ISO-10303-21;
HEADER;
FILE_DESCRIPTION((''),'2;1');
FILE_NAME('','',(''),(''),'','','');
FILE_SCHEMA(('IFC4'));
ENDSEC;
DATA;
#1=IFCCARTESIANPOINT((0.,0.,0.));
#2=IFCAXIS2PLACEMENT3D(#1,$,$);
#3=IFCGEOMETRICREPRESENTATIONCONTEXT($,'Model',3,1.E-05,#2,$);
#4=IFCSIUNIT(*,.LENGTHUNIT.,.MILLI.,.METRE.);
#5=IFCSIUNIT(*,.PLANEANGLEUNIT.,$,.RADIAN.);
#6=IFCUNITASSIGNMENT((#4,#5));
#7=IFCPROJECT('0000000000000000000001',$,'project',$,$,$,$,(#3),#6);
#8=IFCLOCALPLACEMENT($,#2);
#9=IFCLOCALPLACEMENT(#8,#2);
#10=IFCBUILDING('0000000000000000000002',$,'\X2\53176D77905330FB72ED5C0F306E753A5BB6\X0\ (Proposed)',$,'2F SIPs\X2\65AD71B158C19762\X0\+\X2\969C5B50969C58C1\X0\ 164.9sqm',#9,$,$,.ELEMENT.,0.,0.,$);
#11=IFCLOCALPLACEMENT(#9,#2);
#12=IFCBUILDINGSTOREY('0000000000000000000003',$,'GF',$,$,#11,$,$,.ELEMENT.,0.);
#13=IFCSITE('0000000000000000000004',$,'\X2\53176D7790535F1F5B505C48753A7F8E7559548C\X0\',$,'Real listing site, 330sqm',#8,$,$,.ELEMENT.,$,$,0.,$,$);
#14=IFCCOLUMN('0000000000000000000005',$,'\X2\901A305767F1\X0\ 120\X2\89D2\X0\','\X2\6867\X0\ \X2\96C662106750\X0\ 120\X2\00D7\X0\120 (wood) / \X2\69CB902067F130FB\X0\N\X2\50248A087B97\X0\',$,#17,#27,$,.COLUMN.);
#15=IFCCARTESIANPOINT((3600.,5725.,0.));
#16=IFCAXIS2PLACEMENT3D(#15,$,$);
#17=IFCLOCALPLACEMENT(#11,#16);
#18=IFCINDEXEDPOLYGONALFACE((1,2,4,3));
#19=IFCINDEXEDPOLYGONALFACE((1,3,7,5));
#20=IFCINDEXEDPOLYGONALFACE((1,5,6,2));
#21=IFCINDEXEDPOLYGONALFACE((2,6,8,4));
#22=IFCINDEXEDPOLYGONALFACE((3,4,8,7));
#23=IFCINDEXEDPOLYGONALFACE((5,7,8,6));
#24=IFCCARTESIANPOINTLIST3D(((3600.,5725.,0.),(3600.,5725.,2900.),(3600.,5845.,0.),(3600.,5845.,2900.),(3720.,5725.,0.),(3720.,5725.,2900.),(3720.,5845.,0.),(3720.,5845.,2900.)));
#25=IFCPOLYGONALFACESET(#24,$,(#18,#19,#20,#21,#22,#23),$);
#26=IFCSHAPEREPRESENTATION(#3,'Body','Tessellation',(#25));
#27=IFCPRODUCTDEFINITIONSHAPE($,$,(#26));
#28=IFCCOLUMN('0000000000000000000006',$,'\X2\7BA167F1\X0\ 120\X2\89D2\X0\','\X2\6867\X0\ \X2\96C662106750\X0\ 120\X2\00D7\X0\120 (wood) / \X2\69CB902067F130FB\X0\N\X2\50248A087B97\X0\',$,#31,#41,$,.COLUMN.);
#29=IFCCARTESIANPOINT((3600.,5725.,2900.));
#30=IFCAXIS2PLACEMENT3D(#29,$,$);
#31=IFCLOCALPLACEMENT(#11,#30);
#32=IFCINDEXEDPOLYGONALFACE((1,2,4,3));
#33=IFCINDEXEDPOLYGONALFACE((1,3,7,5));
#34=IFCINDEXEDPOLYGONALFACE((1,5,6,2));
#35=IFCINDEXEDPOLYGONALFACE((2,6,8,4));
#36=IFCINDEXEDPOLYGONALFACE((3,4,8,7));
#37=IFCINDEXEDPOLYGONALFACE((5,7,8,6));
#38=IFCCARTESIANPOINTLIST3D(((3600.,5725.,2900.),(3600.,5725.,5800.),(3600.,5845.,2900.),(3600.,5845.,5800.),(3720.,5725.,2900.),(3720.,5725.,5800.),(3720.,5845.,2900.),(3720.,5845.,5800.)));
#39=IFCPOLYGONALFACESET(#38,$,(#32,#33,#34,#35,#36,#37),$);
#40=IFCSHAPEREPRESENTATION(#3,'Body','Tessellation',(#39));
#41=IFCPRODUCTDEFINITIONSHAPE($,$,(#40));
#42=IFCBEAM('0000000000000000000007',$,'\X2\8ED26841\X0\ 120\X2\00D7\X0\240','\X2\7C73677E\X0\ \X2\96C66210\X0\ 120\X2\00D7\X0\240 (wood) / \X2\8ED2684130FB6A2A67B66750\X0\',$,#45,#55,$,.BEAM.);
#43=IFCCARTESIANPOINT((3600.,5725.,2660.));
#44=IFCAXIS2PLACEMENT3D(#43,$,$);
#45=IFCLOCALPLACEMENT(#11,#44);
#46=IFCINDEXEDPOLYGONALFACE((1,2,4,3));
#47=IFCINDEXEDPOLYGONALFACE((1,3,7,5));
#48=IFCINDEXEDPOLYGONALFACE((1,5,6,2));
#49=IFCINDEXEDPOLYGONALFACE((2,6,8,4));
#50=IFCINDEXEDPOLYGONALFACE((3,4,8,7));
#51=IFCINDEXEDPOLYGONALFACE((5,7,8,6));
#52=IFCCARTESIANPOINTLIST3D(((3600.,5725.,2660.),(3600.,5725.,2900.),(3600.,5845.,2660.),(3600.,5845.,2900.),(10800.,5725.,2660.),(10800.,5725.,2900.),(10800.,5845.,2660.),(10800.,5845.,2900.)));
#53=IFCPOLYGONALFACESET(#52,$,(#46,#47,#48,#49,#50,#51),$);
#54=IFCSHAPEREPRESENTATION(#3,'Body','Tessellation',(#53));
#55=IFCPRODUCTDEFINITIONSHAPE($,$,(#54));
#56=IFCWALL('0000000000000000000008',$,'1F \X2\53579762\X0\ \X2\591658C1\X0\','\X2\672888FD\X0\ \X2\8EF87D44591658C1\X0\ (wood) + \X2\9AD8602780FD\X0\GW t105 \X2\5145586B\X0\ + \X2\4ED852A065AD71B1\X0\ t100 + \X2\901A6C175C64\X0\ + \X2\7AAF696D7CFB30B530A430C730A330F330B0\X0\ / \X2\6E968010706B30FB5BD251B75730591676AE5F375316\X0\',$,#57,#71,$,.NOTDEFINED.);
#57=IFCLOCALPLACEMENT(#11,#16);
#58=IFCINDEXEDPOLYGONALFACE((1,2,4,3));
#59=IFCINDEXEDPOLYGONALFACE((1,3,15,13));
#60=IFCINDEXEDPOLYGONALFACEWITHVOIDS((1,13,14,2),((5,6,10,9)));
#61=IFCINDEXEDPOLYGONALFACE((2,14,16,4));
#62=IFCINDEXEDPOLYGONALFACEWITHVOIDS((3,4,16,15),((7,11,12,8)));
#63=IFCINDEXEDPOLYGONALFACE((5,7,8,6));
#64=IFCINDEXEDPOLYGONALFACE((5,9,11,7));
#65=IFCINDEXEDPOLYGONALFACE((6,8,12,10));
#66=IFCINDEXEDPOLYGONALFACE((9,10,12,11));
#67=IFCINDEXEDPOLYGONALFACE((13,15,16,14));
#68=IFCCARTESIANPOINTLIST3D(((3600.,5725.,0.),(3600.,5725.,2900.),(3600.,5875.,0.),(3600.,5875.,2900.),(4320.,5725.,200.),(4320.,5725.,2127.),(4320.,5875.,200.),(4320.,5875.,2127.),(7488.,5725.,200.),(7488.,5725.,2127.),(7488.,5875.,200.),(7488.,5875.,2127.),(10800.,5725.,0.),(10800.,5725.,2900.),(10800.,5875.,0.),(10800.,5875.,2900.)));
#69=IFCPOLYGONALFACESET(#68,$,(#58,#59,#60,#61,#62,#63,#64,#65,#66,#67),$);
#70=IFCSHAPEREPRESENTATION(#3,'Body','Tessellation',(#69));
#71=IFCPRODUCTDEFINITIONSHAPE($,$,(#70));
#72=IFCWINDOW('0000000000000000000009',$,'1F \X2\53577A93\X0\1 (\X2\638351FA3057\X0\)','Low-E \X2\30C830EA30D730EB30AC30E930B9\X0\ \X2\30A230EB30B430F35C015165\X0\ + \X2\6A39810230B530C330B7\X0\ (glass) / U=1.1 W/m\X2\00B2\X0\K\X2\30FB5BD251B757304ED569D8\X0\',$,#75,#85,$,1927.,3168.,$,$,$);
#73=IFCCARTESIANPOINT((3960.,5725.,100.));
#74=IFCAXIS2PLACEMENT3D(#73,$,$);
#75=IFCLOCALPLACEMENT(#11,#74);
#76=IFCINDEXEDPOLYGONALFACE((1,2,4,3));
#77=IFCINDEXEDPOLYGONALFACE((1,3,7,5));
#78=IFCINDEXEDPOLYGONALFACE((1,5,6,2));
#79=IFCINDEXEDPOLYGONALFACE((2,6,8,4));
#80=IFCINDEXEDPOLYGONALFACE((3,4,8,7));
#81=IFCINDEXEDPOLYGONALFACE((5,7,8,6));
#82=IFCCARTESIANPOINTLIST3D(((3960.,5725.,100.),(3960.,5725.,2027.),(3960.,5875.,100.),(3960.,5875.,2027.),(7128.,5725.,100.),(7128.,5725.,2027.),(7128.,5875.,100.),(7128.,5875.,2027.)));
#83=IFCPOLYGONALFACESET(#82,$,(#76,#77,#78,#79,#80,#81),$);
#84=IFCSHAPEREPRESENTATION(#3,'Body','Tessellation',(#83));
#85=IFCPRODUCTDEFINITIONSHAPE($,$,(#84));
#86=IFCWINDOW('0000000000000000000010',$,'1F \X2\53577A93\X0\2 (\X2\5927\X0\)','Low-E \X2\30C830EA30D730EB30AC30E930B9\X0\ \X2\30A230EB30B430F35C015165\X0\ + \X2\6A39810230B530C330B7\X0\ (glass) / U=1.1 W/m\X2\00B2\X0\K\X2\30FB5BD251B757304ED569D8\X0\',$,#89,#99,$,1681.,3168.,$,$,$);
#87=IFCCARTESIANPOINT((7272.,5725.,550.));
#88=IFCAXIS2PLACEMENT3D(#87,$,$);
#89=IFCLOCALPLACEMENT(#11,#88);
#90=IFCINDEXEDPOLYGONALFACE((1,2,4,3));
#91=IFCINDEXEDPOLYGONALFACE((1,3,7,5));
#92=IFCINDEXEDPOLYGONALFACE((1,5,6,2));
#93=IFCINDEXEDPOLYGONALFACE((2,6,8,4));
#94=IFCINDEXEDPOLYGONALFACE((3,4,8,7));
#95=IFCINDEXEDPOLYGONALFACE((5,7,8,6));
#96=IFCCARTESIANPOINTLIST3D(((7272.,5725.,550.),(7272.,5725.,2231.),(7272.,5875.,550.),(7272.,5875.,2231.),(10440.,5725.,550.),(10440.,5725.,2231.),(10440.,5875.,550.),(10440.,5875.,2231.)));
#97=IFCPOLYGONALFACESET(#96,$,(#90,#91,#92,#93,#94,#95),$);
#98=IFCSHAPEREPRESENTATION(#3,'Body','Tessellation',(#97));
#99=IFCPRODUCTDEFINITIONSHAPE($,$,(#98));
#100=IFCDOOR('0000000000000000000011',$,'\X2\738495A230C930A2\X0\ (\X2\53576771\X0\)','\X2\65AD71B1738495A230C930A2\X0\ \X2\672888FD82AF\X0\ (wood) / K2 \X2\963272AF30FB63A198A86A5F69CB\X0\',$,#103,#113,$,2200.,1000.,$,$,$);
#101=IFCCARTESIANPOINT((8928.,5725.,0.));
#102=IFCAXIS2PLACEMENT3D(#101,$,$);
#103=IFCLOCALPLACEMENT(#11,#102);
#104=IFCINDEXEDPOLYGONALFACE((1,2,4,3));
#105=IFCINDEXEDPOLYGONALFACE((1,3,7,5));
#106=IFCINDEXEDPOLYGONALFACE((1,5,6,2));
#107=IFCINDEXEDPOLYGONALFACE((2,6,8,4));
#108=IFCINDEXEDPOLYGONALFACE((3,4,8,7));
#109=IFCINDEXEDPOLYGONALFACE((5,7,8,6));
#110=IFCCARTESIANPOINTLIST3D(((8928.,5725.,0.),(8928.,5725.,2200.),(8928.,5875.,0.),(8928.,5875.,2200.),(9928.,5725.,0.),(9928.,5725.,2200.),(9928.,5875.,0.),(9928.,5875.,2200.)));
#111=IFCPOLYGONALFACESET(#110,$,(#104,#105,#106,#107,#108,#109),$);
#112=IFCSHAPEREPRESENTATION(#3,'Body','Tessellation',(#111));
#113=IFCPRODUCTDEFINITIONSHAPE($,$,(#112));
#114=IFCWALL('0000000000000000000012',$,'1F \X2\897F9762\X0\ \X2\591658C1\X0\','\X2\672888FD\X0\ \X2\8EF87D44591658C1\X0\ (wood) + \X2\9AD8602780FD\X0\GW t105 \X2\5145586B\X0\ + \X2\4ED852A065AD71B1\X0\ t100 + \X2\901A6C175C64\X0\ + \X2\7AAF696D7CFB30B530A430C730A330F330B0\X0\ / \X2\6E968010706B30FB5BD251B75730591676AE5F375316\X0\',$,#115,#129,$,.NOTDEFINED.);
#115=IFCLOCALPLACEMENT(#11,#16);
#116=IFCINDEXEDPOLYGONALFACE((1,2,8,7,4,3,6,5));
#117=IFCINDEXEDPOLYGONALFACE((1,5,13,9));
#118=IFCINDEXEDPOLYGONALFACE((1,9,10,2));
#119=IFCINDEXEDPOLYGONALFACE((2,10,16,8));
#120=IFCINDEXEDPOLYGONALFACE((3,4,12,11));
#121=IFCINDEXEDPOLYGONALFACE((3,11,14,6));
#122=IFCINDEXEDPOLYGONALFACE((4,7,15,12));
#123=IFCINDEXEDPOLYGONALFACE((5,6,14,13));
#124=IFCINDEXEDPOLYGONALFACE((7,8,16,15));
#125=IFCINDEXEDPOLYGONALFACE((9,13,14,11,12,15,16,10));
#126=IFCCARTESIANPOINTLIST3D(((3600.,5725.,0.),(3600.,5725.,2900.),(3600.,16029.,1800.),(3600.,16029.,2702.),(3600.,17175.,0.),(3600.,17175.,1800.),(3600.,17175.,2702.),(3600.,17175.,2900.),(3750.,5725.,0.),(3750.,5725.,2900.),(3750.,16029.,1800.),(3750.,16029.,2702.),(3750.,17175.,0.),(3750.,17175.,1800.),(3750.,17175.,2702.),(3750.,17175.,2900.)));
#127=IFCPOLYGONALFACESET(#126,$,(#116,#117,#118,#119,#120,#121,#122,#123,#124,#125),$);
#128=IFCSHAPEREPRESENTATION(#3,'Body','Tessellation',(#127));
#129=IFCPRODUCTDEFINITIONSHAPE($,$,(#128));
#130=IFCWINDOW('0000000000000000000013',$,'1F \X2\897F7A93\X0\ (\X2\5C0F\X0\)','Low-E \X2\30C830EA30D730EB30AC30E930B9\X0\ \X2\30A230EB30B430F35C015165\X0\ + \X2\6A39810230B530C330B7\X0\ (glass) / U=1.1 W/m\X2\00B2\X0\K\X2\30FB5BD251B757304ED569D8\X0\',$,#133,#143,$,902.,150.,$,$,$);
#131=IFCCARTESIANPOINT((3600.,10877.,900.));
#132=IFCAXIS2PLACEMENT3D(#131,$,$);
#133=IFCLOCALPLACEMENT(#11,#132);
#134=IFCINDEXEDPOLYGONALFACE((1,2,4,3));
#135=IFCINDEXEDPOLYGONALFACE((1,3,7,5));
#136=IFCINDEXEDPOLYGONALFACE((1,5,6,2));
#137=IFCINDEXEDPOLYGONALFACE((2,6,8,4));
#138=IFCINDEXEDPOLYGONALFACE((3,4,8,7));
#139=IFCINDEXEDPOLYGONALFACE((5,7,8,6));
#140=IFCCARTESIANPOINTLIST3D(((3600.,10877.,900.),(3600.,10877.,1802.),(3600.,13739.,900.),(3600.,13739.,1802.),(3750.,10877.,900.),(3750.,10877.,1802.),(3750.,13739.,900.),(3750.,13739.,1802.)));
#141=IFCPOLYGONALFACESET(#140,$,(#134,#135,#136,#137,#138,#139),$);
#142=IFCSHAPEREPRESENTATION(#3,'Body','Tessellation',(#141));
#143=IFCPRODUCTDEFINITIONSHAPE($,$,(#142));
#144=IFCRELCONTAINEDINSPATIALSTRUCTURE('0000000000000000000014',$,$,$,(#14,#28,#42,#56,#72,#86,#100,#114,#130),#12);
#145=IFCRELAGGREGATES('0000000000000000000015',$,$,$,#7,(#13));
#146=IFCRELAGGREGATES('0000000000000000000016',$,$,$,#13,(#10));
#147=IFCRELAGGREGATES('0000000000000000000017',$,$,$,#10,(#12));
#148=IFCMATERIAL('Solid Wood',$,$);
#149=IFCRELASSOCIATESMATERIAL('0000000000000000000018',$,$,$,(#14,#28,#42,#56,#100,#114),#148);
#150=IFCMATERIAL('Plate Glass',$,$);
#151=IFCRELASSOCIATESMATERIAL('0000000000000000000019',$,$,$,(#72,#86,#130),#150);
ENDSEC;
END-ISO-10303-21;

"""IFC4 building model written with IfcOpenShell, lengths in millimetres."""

from ifc_helpers import new_model, si_unit, frame, frame_2d, origin, place, context, project, spatial, rectangle, extrude, material, element, fill, save


model = new_model("IFC4")

# Units and contexts
model_context = context("Model", 3, precision=1e-05, world=origin())
ifc_project = project(units=[si_unit("LENGTHUNIT", "METRE", prefix="MILLI"), si_unit("PLANEANGLEUNIT", "RADIAN")], contexts=[model_context])

# Site, building, storey
site_placement = place(None, origin())
site = spatial("IfcSite", under=ifc_project, at=site_placement, Name="北海道弟子屈町美留和", ObjectType="Real listing site, 330sqm", CompositionType="ELEMENT", RefElevation=0.0)
building_placement = place(site_placement, origin())
building = spatial("IfcBuilding", under=site, at=building_placement, Name="北海道・狭小の町家 (Proposed)", ObjectType="2F SIPs断熱壁面+障子障壁 164.9sqm", CompositionType="ELEMENT", ElevationOfRefHeight=0.0, ElevationOfTerrain=0.0)
storey_placement = place(building_placement, origin())
storey = spatial("IfcBuildingStorey", under=building, at=storey_placement, Name="GF", CompositionType="ELEMENT", Elevation=0.0)

# Columns
ifc_material_1 = material(Name="Solid Wood")
column_1_placement = place(storey_placement, frame((3600.0, 5725.0, 0.0)))
element("IfcColumn", 1, at=column_1_placement, inside=storey, material=ifc_material_1, Name="通し柱 120角", Description="桧 集成材 120×120 (wood) / 構造柱・N値計算", PredefinedType="COLUMN", context=model_context, shape_type="SweptSolid", body=[
    extrude(rectangle(XDim=120.0, YDim=120.0, at=frame_2d((60.0, 60.0))), frame((3600.0, 5725.0, 0.0)), (0.0, 0.0, 1.0), 2900.0),
])
column_2_placement = place(storey_placement, frame((3600.0, 5725.0, 2900.0)))
element("IfcColumn", 2, at=column_2_placement, inside=storey, material=ifc_material_1, Name="管柱 120角", Description="桧 集成材 120×120 (wood) / 構造柱・N値計算", PredefinedType="COLUMN", context=model_context, shape_type="SweptSolid", body=[
    extrude(rectangle(XDim=120.0, YDim=120.0, at=frame_2d((60.0, 60.0))), frame((3600.0, 5725.0, 2900.0)), (0.0, 0.0, 1.0), 2900.0),
])

# Beam
beam_1_placement = place(storey_placement, frame((3600.0, 5725.0, 2660.0)))
element("IfcBeam", 3, at=beam_1_placement, inside=storey, material=ifc_material_1, Name="軒桁 120×240", Description="米松 集成 120×240 (wood) / 軒桁・横架材", PredefinedType="BEAM", context=model_context, shape_type="SweptSolid", body=[
    extrude(rectangle(XDim=7200.0, YDim=120.0, at=frame_2d((3600.0, 60.0))), frame((3600.0, 5725.0, 2660.0)), (0.0, 0.0, 1.0), 240.0),
])

# Wall, openings, windows, door
wall_1_placement = place(storey_placement, frame((3600.0, 5725.0, 0.0)))
wall_1 = element("IfcWall", 4, at=wall_1_placement, inside=storey, material=ifc_material_1, Name="1F 南面 外壁", Description="木製 軸組外壁 (wood) + 高性能GW t105 充填 + 付加断熱 t100 + 通気層 + 窯業系サイディング / 準耐火・寒冷地外皮強化", PredefinedType="NOTDEFINED", context=model_context, shape_type="SweptSolid", body=[
    extrude(rectangle(XDim=7200.0, YDim=150.0, at=frame_2d((3600.0, 75.0))), frame((3600.0, 5725.0, 0.0)), (0.0, 0.0, 1.0), 2900.0),
])
opening_1_placement = place(storey_placement, frame((3960.0, 5725.0, 100.0)))
opening_1 = element("IfcOpeningElement", 5, at=opening_1_placement, cuts=wall_1, PredefinedType="NOTDEFINED", context=model_context, shape_type="SweptSolid", body=[
    extrude(rectangle(XDim=3168.0, YDim=150.0, at=frame_2d((1584.0, 75.0))), frame((3960.0, 5725.0, 100.0)), (0.0, 0.0, 1.0), 1927.0),
])
opening_2_placement = place(storey_placement, frame((7272.0, 5725.0, 550.0)))
opening_2 = element("IfcOpeningElement", 6, at=opening_2_placement, cuts=wall_1, PredefinedType="NOTDEFINED", context=model_context, shape_type="SweptSolid", body=[
    extrude(rectangle(XDim=3168.0, YDim=150.0, at=frame_2d((1584.0, 75.0))), frame((7272.0, 5725.0, 550.0)), (0.0, 0.0, 1.0), 1681.0),
])
opening_3_placement = place(storey_placement, frame((8928.0, 5725.0, 0.0)))
opening_3 = element("IfcOpeningElement", 7, at=opening_3_placement, cuts=wall_1, PredefinedType="NOTDEFINED", context=model_context, shape_type="SweptSolid", body=[
    extrude(rectangle(XDim=1000.0, YDim=150.0, at=frame_2d((500.0, 75.0))), frame((8928.0, 5725.0, 0.0)), (0.0, 0.0, 1.0), 2200.0),
])
ifc_material_2 = material(Name="Plate Glass")
window_1_placement = place(storey_placement, frame((3960.0, 5725.0, 100.0)))
window_1 = element("IfcWindow", 8, at=window_1_placement, inside=storey, material=ifc_material_2, Name="1F 南窓1 (掃出し)", Description="Low-E トリプルガラス アルゴン封入 + 樹脂サッシ (glass) / U=1.1 W/m²K・寒冷地仕様", OverallHeight=1927.0, OverallWidth=3168.0, context=model_context, shape_type="SweptSolid", body=[
    extrude(rectangle(XDim=3168.0, YDim=150.0, at=frame_2d((1584.0, 75.0))), frame((3960.0, 5725.0, 100.0)), (0.0, 0.0, 1.0), 1927.0),
])
fill(opening_1, window_1)
window_2_placement = place(storey_placement, frame((7272.0, 5725.0, 550.0)))
window_2 = element("IfcWindow", 9, at=window_2_placement, inside=storey, material=ifc_material_2, Name="1F 南窓2 (大)", Description="Low-E トリプルガラス アルゴン封入 + 樹脂サッシ (glass) / U=1.1 W/m²K・寒冷地仕様", OverallHeight=1681.0, OverallWidth=3168.0, context=model_context, shape_type="SweptSolid", body=[
    extrude(rectangle(XDim=3168.0, YDim=150.0, at=frame_2d((1584.0, 75.0))), frame((7272.0, 5725.0, 550.0)), (0.0, 0.0, 1.0), 1681.0),
])
fill(opening_2, window_2)
door_placement = place(storey_placement, frame((8928.0, 5725.0, 0.0)))
door = element("IfcDoor", 10, at=door_placement, inside=storey, material=ifc_material_1, Name="玄関ドア (南東)", Description="断熱玄関ドア 木製芯 (wood) / K2 防犯・採風機構", OverallHeight=2200.0, OverallWidth=1000.0, context=model_context, shape_type="SweptSolid", body=[
    extrude(rectangle(XDim=1000.0, YDim=150.0, at=frame_2d((500.0, 75.0))), frame((8928.0, 5725.0, 0.0)), (0.0, 0.0, 1.0), 2200.0),
])
fill(opening_3, door)

# Wall, opening, window
wall_2_placement = place(storey_placement, frame((3600.0, 5725.0, 0.0)))
wall_2 = element("IfcWall", 11, at=wall_2_placement, inside=storey, material=ifc_material_1, Name="1F 西面 外壁", Description="木製 軸組外壁 (wood) + 高性能GW t105 充填 + 付加断熱 t100 + 通気層 + 窯業系サイディング / 準耐火・寒冷地外皮強化", PredefinedType="NOTDEFINED", context=model_context, shape_type="SweptSolid", body=[
    extrude(rectangle(XDim=150.0, YDim=11450.0, at=frame_2d((75.0, 5725.0))), frame((3600.0, 5725.0, 0.0)), (0.0, 0.0, 1.0), 2900.0),
])
opening_4_placement = place(storey_placement, frame((3600.0, 10877.0, 900.0)))
opening_4 = element("IfcOpeningElement", 12, at=opening_4_placement, cuts=wall_2, PredefinedType="NOTDEFINED", context=model_context, shape_type="SweptSolid", body=[
    extrude(rectangle(XDim=150.0, YDim=2862.0, at=frame_2d((75.0, 1431.0))), frame((3600.0, 10877.0, 900.0)), (0.0, 0.0, 1.0), 902.0),
])
window_3_placement = place(storey_placement, frame((3600.0, 10877.0, 900.0)))
window_3 = element("IfcWindow", 13, at=window_3_placement, inside=storey, material=ifc_material_2, Name="1F 西窓 (小)", Description="Low-E トリプルガラス アルゴン封入 + 樹脂サッシ (glass) / U=1.1 W/m²K・寒冷地仕様", OverallHeight=902.0, OverallWidth=150.0, context=model_context, shape_type="SweptSolid", body=[
    extrude(rectangle(XDim=150.0, YDim=2862.0, at=frame_2d((75.0, 1431.0))), frame((3600.0, 10877.0, 900.0)), (0.0, 0.0, 1.0), 902.0),
])
fill(opening_4, window_3)

save(model, "model.ifc")
